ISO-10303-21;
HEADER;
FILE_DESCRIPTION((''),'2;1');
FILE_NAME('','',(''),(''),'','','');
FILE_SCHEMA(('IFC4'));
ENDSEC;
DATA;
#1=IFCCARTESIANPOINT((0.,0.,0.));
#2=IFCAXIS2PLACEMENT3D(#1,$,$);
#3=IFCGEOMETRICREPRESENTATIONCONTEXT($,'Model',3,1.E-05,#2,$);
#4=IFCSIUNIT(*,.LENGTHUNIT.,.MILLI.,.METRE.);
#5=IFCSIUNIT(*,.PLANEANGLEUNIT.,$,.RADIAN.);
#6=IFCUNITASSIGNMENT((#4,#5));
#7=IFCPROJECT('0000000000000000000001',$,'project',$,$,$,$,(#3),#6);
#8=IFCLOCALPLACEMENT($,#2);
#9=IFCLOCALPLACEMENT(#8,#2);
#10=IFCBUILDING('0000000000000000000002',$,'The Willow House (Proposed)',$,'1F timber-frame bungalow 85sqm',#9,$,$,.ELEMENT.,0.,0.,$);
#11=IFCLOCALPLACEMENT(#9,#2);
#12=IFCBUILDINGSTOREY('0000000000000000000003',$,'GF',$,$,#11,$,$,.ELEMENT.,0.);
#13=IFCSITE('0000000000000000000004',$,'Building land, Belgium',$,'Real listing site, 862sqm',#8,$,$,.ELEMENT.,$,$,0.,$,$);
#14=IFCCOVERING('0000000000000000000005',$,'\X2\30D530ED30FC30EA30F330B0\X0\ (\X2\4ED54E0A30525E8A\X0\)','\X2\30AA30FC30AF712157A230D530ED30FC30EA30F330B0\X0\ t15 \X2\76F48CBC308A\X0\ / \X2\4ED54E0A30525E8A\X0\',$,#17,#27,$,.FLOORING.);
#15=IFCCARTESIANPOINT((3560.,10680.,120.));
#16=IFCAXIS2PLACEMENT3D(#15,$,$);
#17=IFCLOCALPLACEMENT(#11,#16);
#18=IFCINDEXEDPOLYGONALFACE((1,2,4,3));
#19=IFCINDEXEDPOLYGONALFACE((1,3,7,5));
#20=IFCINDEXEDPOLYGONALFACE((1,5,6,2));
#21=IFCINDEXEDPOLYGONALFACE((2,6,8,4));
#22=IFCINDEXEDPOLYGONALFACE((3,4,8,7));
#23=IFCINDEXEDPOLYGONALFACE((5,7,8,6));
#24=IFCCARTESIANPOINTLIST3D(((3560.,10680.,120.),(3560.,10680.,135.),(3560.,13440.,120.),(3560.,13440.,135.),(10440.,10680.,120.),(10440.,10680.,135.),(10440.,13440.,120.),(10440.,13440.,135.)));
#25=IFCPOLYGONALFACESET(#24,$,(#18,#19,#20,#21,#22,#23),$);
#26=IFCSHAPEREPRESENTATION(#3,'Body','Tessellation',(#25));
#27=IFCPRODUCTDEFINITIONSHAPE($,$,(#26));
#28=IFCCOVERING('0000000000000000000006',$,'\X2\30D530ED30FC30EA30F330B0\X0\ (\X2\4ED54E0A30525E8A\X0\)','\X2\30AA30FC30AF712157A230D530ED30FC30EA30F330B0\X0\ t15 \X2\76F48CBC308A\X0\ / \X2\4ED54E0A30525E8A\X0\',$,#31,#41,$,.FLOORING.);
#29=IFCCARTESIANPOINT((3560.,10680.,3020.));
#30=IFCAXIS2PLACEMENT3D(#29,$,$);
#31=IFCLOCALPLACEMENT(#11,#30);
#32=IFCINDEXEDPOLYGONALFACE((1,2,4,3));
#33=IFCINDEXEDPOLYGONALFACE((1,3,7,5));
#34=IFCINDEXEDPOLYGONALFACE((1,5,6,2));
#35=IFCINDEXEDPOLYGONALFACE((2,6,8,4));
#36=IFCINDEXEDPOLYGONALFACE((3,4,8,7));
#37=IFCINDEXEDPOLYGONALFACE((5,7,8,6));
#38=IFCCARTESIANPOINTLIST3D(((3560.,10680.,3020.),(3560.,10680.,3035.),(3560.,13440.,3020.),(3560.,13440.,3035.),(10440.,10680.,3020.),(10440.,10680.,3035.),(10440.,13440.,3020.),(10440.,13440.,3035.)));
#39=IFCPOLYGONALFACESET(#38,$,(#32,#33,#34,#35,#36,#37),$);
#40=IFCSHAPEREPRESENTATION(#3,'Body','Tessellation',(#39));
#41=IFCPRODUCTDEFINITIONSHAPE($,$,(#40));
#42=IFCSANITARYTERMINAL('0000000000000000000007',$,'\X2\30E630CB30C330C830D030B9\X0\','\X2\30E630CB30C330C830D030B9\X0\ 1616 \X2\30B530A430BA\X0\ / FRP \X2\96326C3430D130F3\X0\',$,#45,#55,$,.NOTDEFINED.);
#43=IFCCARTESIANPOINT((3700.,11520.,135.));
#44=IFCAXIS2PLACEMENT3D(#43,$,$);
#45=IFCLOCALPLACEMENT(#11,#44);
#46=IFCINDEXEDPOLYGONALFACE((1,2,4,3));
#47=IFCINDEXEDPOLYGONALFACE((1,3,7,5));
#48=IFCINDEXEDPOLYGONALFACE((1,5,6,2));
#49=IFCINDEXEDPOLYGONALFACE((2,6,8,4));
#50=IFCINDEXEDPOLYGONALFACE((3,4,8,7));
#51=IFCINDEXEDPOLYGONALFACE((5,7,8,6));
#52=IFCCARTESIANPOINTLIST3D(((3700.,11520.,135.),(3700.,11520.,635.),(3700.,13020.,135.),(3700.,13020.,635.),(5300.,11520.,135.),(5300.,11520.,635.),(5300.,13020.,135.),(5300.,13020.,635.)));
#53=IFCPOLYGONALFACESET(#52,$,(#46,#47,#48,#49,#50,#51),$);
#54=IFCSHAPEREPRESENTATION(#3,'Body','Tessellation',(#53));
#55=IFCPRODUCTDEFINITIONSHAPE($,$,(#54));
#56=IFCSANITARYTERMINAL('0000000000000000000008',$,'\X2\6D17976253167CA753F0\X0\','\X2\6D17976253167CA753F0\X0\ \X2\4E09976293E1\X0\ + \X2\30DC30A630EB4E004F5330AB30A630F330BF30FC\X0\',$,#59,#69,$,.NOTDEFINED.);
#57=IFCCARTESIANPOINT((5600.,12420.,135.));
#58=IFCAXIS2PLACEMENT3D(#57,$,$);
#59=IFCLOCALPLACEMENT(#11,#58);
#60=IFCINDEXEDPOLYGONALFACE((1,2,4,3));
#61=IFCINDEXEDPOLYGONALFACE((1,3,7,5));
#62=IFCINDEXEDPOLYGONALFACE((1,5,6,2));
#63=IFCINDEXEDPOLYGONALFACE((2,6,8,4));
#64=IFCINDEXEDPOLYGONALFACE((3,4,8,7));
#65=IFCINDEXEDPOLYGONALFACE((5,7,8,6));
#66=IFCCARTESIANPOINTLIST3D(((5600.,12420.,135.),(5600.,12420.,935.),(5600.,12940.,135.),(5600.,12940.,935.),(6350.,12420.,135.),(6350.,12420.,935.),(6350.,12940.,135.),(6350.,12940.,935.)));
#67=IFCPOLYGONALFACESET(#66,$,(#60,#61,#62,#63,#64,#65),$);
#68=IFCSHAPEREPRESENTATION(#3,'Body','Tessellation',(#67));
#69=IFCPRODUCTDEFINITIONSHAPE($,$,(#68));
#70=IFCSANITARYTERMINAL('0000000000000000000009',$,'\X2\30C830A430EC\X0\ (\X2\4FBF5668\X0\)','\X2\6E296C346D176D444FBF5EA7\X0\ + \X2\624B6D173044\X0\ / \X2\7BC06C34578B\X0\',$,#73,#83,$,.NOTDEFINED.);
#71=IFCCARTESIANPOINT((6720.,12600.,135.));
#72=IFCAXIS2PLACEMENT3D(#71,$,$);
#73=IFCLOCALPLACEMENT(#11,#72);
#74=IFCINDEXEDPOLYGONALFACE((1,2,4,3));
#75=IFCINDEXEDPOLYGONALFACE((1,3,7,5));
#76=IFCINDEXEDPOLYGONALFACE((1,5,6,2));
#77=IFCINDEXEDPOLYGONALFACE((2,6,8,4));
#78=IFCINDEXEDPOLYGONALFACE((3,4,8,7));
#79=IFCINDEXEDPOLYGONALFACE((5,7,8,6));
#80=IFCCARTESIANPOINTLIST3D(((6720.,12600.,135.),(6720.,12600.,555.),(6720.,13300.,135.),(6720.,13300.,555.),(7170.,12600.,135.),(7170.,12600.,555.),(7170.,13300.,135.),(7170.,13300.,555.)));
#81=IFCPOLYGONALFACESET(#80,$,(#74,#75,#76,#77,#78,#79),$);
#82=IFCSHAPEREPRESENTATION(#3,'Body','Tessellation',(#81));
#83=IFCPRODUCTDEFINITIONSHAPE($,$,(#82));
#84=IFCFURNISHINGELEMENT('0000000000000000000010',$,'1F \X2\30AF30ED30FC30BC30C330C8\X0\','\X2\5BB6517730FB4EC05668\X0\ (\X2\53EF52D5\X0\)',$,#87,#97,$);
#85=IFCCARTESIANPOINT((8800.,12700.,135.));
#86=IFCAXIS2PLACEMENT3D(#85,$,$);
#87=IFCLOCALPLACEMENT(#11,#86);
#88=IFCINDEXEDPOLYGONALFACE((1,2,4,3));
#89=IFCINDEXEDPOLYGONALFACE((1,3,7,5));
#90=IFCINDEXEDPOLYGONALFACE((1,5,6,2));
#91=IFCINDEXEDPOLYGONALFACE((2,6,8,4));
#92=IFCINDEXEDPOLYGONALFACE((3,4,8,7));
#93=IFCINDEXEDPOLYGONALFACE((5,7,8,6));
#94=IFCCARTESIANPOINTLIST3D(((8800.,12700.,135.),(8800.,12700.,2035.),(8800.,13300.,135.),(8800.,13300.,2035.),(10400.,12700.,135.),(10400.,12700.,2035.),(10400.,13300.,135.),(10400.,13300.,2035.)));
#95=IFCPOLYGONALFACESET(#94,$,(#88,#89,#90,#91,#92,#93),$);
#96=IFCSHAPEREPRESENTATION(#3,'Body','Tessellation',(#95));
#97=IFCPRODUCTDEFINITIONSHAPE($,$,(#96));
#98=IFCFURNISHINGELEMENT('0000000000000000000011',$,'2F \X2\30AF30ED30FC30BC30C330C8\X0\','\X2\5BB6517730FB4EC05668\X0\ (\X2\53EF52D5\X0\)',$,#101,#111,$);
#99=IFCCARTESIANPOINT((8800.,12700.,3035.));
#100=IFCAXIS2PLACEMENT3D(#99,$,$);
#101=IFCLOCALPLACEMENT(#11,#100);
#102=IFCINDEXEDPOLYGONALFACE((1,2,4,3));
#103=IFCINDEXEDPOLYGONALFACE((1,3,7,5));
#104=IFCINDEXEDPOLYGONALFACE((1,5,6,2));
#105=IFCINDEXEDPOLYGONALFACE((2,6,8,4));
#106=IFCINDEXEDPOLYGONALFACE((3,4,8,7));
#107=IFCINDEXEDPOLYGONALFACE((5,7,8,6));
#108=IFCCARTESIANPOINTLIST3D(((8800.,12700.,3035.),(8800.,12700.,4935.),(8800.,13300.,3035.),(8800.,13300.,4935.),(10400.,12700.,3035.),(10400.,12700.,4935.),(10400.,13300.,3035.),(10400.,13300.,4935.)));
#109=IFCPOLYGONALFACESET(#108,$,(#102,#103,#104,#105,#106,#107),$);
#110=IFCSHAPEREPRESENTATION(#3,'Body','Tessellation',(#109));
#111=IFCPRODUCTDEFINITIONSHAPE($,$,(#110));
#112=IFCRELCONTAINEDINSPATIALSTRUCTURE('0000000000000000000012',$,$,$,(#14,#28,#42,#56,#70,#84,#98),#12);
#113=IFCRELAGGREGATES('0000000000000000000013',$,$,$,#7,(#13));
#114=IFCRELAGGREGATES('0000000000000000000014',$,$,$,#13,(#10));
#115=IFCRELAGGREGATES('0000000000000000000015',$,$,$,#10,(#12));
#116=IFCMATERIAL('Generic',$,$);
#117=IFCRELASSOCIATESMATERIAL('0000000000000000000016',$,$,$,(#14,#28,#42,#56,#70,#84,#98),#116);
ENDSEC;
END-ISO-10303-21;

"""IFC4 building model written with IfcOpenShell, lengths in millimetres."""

from ifc_helpers import new_model, si_unit, frame, frame_2d, origin, place, context, project, spatial, rectangle, extrude, material, element, save


model = new_model("IFC4")

# Units and contexts
model_context = context("Model", 3, precision=1e-05, world=origin())
ifc_project = project(units=[si_unit("LENGTHUNIT", "METRE", prefix="MILLI"), si_unit("PLANEANGLEUNIT", "RADIAN")], contexts=[model_context])

# Site, building, storey
site_placement = place(None, origin())
site = spatial("IfcSite", under=ifc_project, at=site_placement, Name="Building land, Belgium", ObjectType="Real listing site, 862sqm", CompositionType="ELEMENT", RefElevation=0.0)
building_placement = place(site_placement, origin())
building = spatial("IfcBuilding", under=site, at=building_placement, Name="The Willow House (Proposed)", ObjectType="1F timber-frame bungalow 85sqm", CompositionType="ELEMENT", ElevationOfRefHeight=0.0, ElevationOfTerrain=0.0)
storey_placement = place(building_placement, origin())
storey = spatial("IfcBuildingStorey", under=building, at=storey_placement, Name="GF", CompositionType="ELEMENT", Elevation=0.0)

# Coverings
ifc_material_1 = material(Name="Generic")
covering_1_placement = place(storey_placement, frame((3560.0, 10680.0, 120.0)))
element("IfcCovering", 1, at=covering_1_placement, inside=storey, material=ifc_material_1, Name="フローリング (仕上げ床)", Description="オーク無垢フローリング t15 直貼り / 仕上げ床", PredefinedType="FLOORING", context=model_context, shape_type="SweptSolid", body=[
    extrude(rectangle(XDim=6880.0, YDim=2760.0, at=frame_2d((3440.0, 1380.0))), frame((3560.0, 10680.0, 120.0)), (0.0, 0.0, 1.0), 15.0),
])
covering_2_placement = place(storey_placement, frame((3560.0, 10680.0, 3020.0)))
element("IfcCovering", 2, at=covering_2_placement, inside=storey, material=ifc_material_1, Name="フローリング (仕上げ床)", Description="オーク無垢フローリング t15 直貼り / 仕上げ床", PredefinedType="FLOORING", context=model_context, shape_type="SweptSolid", body=[
    extrude(rectangle(XDim=6880.0, YDim=2760.0, at=frame_2d((3440.0, 1380.0))), frame((3560.0, 10680.0, 3020.0)), (0.0, 0.0, 1.0), 15.0),
])

# Sanitary terminals
sanitary_terminal_1_placement = place(storey_placement, frame((3700.0, 11520.0, 135.0)))
element("IfcSanitaryTerminal", 3, at=sanitary_terminal_1_placement, inside=storey, material=ifc_material_1, Name="ユニットバス", Description="ユニットバス 1616 サイズ / FRP 防水パン", PredefinedType="NOTDEFINED", context=model_context, shape_type="SweptSolid", body=[
    extrude(rectangle(XDim=1600.0, YDim=1500.0, at=frame_2d((800.0, 750.0))), frame((3700.0, 11520.0, 135.0)), (0.0, 0.0, 1.0), 500.0),
])
sanitary_terminal_2_placement = place(storey_placement, frame((5600.0, 12420.0, 135.0)))
element("IfcSanitaryTerminal", 4, at=sanitary_terminal_2_placement, inside=storey, material=ifc_material_1, Name="洗面化粧台", Description="洗面化粧台 三面鏡 + ボウル一体カウンター", PredefinedType="NOTDEFINED", context=model_context, shape_type="SweptSolid", body=[
    extrude(rectangle(XDim=750.0, YDim=520.0, at=frame_2d((375.0, 260.0))), frame((5600.0, 12420.0, 135.0)), (0.0, 0.0, 1.0), 800.0),
])
sanitary_terminal_3_placement = place(storey_placement, frame((6720.0, 12600.0, 135.0)))
element("IfcSanitaryTerminal", 5, at=sanitary_terminal_3_placement, inside=storey, material=ifc_material_1, Name="トイレ (便器)", Description="温水洗浄便座 + 手洗い / 節水型", PredefinedType="NOTDEFINED", context=model_context, shape_type="SweptSolid", body=[
    extrude(rectangle(XDim=450.0, YDim=700.0, at=frame_2d((225.0, 350.0))), frame((6720.0, 12600.0, 135.0)), (0.0, 0.0, 1.0), 420.0),
])

# Furnishing elements
furnishing_1_placement = place(storey_placement, frame((8800.0, 12700.0, 135.0)))
element("IfcFurnishingElement", 6, at=furnishing_1_placement, inside=storey, material=ifc_material_1, Name="1F クローゼット", Description="家具・什器 (可動)", context=model_context, shape_type="SweptSolid", body=[
    extrude(rectangle(XDim=1600.0, YDim=600.0, at=frame_2d((800.0, 300.0))), frame((8800.0, 12700.0, 135.0)), (0.0, 0.0, 1.0), 1900.0),
])
furnishing_2_placement = place(storey_placement, frame((8800.0, 12700.0, 3035.0)))
element("IfcFurnishingElement", 7, at=furnishing_2_placement, inside=storey, material=ifc_material_1, Name="2F クローゼット", Description="家具・什器 (可動)", context=model_context, shape_type="SweptSolid", body=[
    extrude(rectangle(XDim=1600.0, YDim=600.0, at=frame_2d((800.0, 300.0))), frame((8800.0, 12700.0, 3035.0)), (0.0, 0.0, 1.0), 1900.0),
])

save(model, "model.ifc")
